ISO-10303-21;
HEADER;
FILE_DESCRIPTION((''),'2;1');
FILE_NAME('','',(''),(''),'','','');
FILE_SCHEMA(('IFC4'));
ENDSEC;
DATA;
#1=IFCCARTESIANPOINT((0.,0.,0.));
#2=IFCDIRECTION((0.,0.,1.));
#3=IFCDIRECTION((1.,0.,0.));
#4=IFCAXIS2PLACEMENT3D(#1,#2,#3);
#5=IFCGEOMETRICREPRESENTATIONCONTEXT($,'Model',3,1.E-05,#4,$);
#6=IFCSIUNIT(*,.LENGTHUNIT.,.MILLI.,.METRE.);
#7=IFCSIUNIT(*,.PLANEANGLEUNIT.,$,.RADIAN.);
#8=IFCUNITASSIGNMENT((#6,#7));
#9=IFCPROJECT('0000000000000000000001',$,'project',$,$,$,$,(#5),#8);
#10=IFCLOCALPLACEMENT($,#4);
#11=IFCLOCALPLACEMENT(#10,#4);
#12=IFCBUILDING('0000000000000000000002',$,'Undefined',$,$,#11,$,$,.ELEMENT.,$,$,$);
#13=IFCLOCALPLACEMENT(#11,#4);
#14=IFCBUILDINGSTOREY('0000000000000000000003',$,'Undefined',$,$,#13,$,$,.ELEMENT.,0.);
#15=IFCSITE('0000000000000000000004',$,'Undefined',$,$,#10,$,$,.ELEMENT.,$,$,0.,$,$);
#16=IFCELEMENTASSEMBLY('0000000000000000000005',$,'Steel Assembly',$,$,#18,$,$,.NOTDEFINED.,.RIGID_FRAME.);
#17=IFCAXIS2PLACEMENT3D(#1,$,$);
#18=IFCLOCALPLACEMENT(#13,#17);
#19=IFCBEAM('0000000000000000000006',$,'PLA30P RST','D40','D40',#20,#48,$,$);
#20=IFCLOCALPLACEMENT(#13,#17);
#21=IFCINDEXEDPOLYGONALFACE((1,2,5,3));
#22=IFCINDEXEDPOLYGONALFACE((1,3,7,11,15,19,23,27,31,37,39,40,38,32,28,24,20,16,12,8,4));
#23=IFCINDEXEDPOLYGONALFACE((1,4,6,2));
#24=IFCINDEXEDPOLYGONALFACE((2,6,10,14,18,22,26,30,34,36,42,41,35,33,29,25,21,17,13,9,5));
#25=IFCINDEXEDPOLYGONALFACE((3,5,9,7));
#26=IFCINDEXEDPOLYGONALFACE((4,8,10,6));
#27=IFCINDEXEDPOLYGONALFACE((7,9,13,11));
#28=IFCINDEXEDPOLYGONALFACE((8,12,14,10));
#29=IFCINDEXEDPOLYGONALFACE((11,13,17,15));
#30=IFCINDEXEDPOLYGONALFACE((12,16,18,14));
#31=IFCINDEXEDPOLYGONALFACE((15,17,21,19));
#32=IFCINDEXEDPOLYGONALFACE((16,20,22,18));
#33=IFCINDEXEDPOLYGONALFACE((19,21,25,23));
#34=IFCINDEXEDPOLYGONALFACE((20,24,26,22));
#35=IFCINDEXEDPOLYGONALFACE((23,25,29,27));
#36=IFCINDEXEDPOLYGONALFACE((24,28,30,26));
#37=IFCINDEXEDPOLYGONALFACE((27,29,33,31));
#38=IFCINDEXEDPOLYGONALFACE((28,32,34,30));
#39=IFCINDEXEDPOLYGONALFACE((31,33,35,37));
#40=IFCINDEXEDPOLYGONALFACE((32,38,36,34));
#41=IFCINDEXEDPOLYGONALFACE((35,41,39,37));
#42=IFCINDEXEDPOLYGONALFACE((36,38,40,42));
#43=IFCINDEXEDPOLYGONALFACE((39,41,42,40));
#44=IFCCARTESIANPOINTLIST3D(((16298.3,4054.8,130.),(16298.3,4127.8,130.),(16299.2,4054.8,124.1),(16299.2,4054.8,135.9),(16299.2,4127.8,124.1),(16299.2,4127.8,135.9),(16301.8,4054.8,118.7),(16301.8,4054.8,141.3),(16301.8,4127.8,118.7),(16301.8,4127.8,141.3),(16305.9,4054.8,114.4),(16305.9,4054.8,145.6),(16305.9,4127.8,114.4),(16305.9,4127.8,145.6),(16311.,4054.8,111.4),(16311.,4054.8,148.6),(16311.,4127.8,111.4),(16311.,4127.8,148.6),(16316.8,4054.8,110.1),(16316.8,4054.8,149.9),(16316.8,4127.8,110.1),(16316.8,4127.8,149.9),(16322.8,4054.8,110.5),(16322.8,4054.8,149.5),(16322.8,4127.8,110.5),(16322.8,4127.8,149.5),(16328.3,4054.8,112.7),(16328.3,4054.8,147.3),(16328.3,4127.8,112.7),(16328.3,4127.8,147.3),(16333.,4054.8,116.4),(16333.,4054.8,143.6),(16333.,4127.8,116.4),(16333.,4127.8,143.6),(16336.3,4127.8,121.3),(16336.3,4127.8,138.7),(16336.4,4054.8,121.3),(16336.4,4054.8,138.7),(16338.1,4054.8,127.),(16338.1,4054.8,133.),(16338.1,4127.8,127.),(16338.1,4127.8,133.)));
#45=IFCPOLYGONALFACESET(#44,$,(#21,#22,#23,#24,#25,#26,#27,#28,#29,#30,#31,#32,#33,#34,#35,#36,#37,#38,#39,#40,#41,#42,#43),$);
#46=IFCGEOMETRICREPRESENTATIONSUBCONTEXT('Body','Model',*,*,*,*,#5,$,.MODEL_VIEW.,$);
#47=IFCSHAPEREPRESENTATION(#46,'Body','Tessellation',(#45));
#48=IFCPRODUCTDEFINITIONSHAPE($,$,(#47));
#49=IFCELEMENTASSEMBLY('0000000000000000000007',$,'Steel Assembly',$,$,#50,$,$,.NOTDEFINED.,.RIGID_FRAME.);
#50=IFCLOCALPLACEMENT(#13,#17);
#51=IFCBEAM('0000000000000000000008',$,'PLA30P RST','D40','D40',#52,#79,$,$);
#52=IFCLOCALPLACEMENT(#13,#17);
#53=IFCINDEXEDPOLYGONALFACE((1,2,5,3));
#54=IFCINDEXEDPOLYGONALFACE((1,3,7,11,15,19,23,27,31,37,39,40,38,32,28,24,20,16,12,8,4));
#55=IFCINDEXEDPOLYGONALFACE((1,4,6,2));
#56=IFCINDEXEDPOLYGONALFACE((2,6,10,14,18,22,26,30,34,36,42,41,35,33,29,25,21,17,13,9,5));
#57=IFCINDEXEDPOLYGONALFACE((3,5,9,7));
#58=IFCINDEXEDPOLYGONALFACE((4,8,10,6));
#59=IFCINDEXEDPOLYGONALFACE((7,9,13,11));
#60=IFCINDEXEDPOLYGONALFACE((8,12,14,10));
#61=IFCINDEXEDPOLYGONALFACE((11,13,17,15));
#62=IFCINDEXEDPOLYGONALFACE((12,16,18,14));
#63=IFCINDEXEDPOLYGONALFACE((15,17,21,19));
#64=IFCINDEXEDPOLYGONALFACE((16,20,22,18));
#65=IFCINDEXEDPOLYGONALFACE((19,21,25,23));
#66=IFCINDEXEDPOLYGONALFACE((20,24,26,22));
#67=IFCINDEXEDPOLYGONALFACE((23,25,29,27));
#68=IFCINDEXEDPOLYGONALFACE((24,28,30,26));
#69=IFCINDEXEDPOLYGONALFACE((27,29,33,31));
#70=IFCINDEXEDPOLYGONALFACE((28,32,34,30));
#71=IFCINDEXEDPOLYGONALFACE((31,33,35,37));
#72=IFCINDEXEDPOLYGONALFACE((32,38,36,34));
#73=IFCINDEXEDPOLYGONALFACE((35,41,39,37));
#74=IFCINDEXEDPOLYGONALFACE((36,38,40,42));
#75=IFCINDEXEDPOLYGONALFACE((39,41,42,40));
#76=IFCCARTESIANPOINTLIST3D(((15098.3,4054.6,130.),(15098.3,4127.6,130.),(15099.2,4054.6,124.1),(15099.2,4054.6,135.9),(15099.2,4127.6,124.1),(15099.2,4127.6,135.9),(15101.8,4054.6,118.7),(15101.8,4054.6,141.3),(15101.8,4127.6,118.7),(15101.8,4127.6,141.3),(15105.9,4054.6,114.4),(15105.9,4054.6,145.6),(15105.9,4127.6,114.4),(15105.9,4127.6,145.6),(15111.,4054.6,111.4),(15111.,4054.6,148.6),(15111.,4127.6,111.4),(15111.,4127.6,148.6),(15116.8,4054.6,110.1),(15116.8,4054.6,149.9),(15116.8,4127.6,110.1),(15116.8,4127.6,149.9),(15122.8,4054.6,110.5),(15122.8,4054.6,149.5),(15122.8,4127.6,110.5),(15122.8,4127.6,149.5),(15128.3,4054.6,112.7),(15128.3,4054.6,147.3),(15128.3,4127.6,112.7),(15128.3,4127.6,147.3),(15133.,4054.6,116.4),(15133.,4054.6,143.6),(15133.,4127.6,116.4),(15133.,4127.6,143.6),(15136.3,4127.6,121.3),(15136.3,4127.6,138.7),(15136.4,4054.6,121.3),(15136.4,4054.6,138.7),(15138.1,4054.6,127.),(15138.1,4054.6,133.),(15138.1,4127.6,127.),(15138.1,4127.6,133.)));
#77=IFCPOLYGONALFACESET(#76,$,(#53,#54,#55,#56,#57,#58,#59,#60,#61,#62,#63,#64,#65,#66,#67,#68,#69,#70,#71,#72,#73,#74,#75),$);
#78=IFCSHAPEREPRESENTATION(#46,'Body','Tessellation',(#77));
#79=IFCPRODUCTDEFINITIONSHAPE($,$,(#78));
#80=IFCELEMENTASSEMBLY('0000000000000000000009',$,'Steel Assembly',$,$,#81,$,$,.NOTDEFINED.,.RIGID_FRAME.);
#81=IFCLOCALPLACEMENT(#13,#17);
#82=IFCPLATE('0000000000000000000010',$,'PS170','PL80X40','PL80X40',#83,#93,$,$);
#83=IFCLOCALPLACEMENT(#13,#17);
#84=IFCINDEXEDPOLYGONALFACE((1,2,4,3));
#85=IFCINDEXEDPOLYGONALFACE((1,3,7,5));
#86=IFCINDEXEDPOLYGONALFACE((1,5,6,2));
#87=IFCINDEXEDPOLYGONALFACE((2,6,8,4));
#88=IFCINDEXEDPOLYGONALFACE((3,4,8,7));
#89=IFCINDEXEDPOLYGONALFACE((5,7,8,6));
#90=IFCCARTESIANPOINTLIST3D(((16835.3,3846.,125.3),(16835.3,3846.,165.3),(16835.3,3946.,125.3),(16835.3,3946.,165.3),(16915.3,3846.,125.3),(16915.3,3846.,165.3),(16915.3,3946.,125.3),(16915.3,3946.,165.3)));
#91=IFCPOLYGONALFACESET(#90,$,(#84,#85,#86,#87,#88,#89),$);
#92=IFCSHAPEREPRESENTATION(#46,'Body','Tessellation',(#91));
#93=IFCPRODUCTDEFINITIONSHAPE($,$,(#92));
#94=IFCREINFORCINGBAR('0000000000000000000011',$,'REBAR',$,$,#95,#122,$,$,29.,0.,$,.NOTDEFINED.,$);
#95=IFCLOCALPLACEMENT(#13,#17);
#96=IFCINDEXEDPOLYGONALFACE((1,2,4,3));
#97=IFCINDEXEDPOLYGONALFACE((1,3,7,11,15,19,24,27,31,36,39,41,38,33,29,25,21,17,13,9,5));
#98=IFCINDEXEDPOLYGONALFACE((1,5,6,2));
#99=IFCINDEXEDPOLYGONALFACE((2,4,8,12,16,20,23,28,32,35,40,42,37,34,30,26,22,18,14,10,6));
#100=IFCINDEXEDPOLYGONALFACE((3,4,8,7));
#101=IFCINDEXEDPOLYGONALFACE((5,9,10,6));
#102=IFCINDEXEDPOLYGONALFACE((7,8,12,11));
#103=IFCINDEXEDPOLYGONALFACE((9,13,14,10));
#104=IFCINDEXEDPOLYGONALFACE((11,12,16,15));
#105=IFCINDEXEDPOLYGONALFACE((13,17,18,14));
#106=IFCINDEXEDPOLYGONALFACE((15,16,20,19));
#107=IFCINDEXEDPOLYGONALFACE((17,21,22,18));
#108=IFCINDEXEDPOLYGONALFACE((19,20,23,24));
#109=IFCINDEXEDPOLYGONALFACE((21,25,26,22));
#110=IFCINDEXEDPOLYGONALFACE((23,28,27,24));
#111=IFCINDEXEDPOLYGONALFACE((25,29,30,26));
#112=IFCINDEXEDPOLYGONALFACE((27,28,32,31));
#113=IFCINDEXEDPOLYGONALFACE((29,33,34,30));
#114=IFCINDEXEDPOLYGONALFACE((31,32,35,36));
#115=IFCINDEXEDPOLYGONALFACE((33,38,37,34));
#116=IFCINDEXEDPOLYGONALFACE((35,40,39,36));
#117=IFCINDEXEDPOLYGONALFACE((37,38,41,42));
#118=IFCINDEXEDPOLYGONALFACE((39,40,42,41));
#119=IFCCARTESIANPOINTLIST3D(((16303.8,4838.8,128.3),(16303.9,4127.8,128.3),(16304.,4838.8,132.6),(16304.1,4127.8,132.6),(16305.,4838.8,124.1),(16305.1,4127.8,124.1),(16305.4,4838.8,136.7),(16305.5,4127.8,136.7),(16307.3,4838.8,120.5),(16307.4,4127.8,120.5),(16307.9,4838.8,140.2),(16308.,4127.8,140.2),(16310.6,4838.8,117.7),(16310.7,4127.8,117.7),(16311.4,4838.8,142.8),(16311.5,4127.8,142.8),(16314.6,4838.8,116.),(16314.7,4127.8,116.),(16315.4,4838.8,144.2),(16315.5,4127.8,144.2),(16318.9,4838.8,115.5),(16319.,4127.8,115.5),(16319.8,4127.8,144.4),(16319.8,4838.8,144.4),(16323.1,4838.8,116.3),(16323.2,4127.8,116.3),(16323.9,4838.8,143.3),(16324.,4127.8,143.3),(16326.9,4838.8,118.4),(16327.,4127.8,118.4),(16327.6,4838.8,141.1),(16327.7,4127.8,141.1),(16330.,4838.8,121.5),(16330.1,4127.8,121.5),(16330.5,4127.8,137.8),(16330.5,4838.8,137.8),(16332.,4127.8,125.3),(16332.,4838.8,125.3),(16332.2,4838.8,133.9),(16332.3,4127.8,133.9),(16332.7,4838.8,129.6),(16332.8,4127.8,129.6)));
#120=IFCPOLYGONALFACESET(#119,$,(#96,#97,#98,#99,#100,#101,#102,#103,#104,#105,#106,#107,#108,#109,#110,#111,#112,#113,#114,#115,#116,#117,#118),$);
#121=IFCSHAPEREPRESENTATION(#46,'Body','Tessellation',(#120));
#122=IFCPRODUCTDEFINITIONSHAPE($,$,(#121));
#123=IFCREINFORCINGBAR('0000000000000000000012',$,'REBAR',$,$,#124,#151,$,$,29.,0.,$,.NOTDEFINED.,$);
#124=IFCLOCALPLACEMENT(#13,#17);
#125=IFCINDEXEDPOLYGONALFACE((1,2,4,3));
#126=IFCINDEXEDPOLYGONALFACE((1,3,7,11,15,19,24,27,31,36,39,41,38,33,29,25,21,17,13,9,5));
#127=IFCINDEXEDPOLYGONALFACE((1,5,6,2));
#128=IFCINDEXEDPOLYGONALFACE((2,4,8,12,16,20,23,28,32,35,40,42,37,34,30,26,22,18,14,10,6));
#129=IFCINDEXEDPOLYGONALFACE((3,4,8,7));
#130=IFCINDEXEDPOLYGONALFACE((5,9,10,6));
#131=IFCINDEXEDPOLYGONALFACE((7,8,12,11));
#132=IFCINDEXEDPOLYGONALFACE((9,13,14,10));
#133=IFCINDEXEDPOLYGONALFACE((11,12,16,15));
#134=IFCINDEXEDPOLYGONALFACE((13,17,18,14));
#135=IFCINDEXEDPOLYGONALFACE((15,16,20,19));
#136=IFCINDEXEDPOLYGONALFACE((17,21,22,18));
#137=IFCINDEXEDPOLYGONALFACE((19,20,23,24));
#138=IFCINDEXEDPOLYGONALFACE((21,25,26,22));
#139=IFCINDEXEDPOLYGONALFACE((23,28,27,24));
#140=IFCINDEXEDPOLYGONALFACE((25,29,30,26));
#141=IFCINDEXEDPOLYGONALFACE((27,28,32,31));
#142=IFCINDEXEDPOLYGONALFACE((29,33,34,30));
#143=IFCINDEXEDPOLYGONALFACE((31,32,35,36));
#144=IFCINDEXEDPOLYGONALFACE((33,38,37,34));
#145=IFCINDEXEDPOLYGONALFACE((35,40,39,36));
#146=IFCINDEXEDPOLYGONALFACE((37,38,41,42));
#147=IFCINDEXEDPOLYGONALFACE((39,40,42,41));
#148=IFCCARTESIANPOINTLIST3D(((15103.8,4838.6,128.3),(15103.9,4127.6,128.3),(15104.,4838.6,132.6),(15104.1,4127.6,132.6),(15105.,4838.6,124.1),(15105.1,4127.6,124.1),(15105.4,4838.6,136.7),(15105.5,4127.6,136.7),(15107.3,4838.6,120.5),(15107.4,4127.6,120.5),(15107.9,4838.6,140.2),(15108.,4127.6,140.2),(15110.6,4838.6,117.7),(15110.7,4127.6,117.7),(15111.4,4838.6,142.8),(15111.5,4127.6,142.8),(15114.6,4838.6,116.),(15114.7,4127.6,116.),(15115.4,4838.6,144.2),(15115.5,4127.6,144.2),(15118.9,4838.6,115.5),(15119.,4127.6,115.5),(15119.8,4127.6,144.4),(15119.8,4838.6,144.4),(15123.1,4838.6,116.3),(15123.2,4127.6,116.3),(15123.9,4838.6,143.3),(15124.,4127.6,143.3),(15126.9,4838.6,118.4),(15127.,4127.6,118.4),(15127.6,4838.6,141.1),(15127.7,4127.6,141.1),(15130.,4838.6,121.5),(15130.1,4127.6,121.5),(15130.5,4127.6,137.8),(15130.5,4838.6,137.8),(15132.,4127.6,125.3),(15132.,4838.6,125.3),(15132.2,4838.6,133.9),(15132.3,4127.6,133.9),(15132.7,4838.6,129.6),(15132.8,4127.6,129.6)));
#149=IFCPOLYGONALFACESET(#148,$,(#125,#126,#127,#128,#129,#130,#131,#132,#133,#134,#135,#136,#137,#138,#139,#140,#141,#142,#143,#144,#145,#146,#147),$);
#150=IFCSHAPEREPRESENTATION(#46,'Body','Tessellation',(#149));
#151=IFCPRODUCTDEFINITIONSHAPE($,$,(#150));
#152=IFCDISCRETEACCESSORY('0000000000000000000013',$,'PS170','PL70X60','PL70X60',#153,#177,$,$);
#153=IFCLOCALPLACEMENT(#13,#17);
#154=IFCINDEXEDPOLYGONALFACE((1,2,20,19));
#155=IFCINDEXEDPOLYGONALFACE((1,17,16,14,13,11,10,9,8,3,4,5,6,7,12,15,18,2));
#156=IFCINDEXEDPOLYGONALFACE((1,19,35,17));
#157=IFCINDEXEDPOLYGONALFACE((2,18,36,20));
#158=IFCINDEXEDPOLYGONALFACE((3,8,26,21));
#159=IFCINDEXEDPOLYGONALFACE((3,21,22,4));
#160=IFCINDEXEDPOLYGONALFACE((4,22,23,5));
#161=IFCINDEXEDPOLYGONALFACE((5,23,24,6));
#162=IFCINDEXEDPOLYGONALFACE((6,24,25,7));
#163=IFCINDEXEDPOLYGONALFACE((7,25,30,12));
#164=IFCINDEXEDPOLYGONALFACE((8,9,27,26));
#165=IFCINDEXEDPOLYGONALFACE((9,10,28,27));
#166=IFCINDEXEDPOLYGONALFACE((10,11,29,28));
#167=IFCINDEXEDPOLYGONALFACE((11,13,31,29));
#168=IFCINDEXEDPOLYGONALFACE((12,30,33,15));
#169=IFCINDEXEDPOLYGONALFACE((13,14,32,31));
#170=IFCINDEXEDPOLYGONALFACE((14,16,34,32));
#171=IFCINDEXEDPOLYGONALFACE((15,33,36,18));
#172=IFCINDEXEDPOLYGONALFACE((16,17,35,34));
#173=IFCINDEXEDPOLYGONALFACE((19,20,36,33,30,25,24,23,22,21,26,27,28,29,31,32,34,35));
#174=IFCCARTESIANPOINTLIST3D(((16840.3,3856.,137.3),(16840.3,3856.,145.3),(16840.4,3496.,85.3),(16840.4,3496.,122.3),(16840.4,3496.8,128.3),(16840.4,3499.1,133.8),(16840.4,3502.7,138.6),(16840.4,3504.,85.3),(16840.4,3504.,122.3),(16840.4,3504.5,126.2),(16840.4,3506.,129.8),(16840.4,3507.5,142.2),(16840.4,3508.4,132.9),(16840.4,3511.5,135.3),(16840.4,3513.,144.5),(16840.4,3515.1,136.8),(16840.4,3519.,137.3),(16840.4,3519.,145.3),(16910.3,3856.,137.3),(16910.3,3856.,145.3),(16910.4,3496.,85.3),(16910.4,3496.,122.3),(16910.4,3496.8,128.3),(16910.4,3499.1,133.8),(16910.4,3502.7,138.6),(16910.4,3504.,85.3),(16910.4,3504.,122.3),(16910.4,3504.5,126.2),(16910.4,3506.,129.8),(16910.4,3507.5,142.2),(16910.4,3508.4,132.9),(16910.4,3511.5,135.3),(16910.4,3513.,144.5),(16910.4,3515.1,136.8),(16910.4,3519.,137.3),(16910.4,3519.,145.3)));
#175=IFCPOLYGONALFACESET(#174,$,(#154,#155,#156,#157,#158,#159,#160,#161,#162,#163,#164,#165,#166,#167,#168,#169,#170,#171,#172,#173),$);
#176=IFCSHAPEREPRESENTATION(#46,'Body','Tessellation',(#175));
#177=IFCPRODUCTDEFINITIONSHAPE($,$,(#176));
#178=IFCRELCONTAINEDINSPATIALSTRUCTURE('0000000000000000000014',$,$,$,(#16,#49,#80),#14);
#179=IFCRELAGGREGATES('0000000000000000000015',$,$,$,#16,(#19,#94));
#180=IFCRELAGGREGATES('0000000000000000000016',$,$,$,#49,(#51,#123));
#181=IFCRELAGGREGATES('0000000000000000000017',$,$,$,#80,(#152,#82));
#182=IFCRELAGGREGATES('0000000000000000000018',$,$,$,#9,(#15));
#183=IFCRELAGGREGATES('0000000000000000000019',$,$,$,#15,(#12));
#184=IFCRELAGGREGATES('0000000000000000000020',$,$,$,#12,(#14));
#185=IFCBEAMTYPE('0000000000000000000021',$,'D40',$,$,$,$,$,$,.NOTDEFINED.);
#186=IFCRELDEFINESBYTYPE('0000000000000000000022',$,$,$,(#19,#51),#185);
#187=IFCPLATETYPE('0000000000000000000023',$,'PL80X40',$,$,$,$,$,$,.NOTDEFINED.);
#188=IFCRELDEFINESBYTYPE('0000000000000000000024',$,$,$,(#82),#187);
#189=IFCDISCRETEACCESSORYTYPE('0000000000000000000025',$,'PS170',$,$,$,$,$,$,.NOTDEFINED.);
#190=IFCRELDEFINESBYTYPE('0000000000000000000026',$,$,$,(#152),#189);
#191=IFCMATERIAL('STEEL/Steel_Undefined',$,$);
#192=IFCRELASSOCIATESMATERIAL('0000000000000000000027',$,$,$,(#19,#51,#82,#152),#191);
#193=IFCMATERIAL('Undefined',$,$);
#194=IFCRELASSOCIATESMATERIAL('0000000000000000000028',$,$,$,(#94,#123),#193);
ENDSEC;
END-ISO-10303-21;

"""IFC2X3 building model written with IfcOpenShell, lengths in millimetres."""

from ifc_helpers import new_model, entity, si_unit, frame, frame_2d, origin_with_axes, origin_2d_with_axis, place, context, subcontext, project, spatial, polyline, circle_curve, parameter, trimmed, segment, composite_curve, circle, outline, extrude, source, transform, mapped, material, type_object, element, aggregate, save


model = new_model("IFC2X3")

# Units and contexts
model_context = context("Model", 3, precision=1e-05, world=origin_with_axes())
body_context = subcontext(model_context, "Body", "Model", "MODEL_VIEW")
ifc_project = project(units=[si_unit("LENGTHUNIT", "METRE", prefix="MILLI"), si_unit("PLANEANGLEUNIT", "RADIAN")], contexts=[model_context])

# Site, building, storey
site_placement = place(None, origin_with_axes())
site = spatial("IfcSite", under=ifc_project, at=site_placement, Name="Undefined", CompositionType="ELEMENT", RefElevation=0.0)
building_placement = place(site_placement, origin_with_axes())
building = spatial("IfcBuilding", under=site, at=building_placement, Name="Undefined", CompositionType="ELEMENT")
storey_placement = place(building_placement, origin_with_axes())
storey = spatial("IfcBuildingStorey", under=building, at=storey_placement, Name="Undefined", CompositionType="ELEMENT", Elevation=0.0)

# Shared definitions
ifc_material_1 = material(Name="STEEL/Steel_Undefined")

# Element assemblies, beams
assembly_1_placement = place(storey_placement, origin_with_axes())
assembly_1 = element("IfcElementAssembly", 1, at=assembly_1_placement, inside=storey, Name="Steel Assembly", AssemblyPlace="NOTDEFINED", PredefinedType="RIGID_FRAME")
beam_type = type_object("IfcBeamType", Name="D40", PredefinedType="NOTDEFINED")
beam_1_placement = place(assembly_1_placement, frame((16318.3, 4127.8, 130.0), z_axis=(-0.000003, 0.000001, 1.0), x_axis=(0.00013, -1.0, 0.000001)))
beam_1 = element("IfcBeam", 2, at=beam_1_placement, type_object=beam_type, material=ifc_material_1, Name="PLA30P RST", Description="D40", ObjectType="D40", context=body_context, shape_type="SweptSolid", body=[
    extrude(circle(Radius=20.0, at=origin_2d_with_axis()), frame((73.0, 0.0, 0.0), z_axis=(-1.0, 0.0, 0.0), x_axis=(0.0, -1.0, 0.0)), (0.0, 0.0, 1.0), 73.0),
])
assembly_2_placement = place(storey_placement, origin_with_axes())
assembly_2 = element("IfcElementAssembly", 3, at=assembly_2_placement, inside=storey, Name="Steel Assembly", AssemblyPlace="NOTDEFINED", PredefinedType="RIGID_FRAME")
beam_2_placement = place(assembly_2_placement, frame((15118.3, 4127.6, 130.0), z_axis=(-0.000003, 0.000001, 1.0), x_axis=(0.00013, -1.0, 0.000001)))
beam_2 = element("IfcBeam", 4, at=beam_2_placement, type_object=beam_type, material=ifc_material_1, Name="PLA30P RST", Description="D40", ObjectType="D40", context=body_context, shape_type="SweptSolid", body=[
    extrude(circle(Radius=20.0, at=origin_2d_with_axis()), frame((73.0, 0.0, 0.0), z_axis=(-1.0, 0.0, 0.0), x_axis=(0.0, -1.0, 0.0)), (0.0, 0.0, 1.0), 73.0),
])

# Element assembly, plate
assembly_3_placement = place(storey_placement, origin_with_axes())
assembly_3 = element("IfcElementAssembly", 5, at=assembly_3_placement, inside=storey, Name="Steel Assembly", AssemblyPlace="NOTDEFINED", PredefinedType="RIGID_FRAME")
plate_type = type_object("IfcPlateType", Name="PL80X40", PredefinedType="NOTDEFINED")
plate_placement = place(assembly_3_placement, frame((16875.3, 3946.0, 125.3), z_axis=(1.0, 0.000183, 0.0), x_axis=(0.0, 0.0, 1.0)))
plate = element("IfcPlate", 6, at=plate_placement, type_object=plate_type, material=ifc_material_1, Name="PS170", Description="PL80X40", ObjectType="PL80X40", context=body_context, shape_type="SweptSolid", body=[
    extrude(outline(polyline([(0.0, 0.0), (40.0, 0.0), (40.0, 100.0), (0.0, 100.0), (0.0, 0.0)])), frame((0.0, 0.0, -40.0), z_axis=(0.0, 0.0, 1.0), x_axis=(1.0, 0.0, 0.0)), (0.0, 0.0, 1.0), 80.0),
])

# Reinforcing bars
ifc_material_2 = material(Name="Undefined")
shared_shape_1 = source(origin_with_axes(), body_context, "Body", "AdvancedSweptSolid", [
    entity("IfcSweptDiskSolid", entity("IfcTrimmedCurve", entity("IfcLine", entity("IfcCartesianPoint", [0.0, 0.0, 0.0]), entity("IfcVector", entity("IfcDirection", [1.0, 0.0, 0.0]), 1.0)), [entity("IfcParameterValue", 0.0)], [entity("IfcParameterValue", 711.0)], True, "PARAMETER"), 14.5, None, 0.0, 711.0),
])
reinforcing_bar_1_placement = place(assembly_1_placement, frame((16318.3, 4127.8, 130.0), z_axis=(0.999549, 0.00013, -0.030038), x_axis=(-0.00013, 1.0, -0.000001)))
reinforcing_bar_1 = element("IfcReinforcingBar", 7, at=reinforcing_bar_1_placement, material=ifc_material_2, Name="REBAR", BarRole="NOTDEFINED", CrossSectionArea=0.0, NominalDiameter=29.0, context=body_context, shape_type="MappedRepresentation", body=[
    mapped(shared_shape_1, transform((0.0, 0.0, 0.0))),
])
aggregate(assembly_1, [beam_1, reinforcing_bar_1])
shared_shape_2 = source(origin_with_axes(), body_context, "Body", "AdvancedSweptSolid", [
    entity("IfcSweptDiskSolid", entity("IfcTrimmedCurve", entity("IfcLine", entity("IfcCartesianPoint", [0.0, 0.0, 0.0]), entity("IfcVector", entity("IfcDirection", [1.0, 0.0, 0.0]), 1.0)), [entity("IfcParameterValue", 0.0)], [entity("IfcParameterValue", 711.0)], True, "PARAMETER"), 14.5, None, 0.0, 711.0),
])
reinforcing_bar_2_placement = place(assembly_2_placement, frame((15118.3, 4127.6, 130.0), z_axis=(0.999549, 0.00013, -0.030038), x_axis=(-0.00013, 1.0, -0.000001)))
reinforcing_bar_2 = element("IfcReinforcingBar", 8, at=reinforcing_bar_2_placement, material=ifc_material_2, Name="REBAR", BarRole="NOTDEFINED", CrossSectionArea=0.0, NominalDiameter=29.0, context=body_context, shape_type="MappedRepresentation", body=[
    mapped(shared_shape_2, transform((0.0, 0.0, 0.0))),
])
aggregate(assembly_2, [beam_2, reinforcing_bar_2])

# Discrete accessory
discrete_accessory_type_1 = type_object("IfcDiscreteAccessoryType", Name="PS170")
discrete_accessory_1_placement = place(assembly_3_placement, frame((16875.3, 3856.0, 145.3), z_axis=(1.0, 0.000183, 0.0), x_axis=(0.000183, -1.0, 0.0)))
discrete_accessory_1 = element("IfcDiscreteAccessory", 9, at=discrete_accessory_1_placement, type_object=discrete_accessory_type_1, material=ifc_material_1, Name="PS170", Description="PL70X60", ObjectType="PL70X60", context=body_context, shape_type="SweptSolid", body=[
    extrude(outline(composite_curve([segment(polyline([(0.0, 0.0), (337.0, 0.0)]), True, "CONTINUOUS"), segment(trimmed(circle_curve(frame_2d((337.0, 23.0), x_axis=(0.0, -1.0)), 23.0), [parameter(0.0)], [parameter(1.570796)], True, "PARAMETER"), True, "CONTINUOUS"), segment(polyline([(360.0, 23.0), (360.0, 60.0), (352.0, 60.0), (352.0, 23.0)]), True, "CONTINUOUS"), segment(trimmed(circle_curve(frame_2d((337.0, 23.0), x_axis=(1.0, 0.0)), 15.0), [parameter(0.0)], [parameter(4.712389)], False, "PARAMETER"), True, "CONTINUOUS"), segment(polyline([(337.0, 8.0), (0.0, 8.0), (0.0, 0.0)]), True, "CONTINUOUS")], self_intersect=True)), frame((0.0, 0.0, -35.0), z_axis=(0.0, 0.0, 1.0), x_axis=(1.0, 0.0, 0.0)), (0.0, 0.0, 1.0), 70.0),
])

aggregate(assembly_3, [discrete_accessory_1, plate])

save(model, "model.ifc")
